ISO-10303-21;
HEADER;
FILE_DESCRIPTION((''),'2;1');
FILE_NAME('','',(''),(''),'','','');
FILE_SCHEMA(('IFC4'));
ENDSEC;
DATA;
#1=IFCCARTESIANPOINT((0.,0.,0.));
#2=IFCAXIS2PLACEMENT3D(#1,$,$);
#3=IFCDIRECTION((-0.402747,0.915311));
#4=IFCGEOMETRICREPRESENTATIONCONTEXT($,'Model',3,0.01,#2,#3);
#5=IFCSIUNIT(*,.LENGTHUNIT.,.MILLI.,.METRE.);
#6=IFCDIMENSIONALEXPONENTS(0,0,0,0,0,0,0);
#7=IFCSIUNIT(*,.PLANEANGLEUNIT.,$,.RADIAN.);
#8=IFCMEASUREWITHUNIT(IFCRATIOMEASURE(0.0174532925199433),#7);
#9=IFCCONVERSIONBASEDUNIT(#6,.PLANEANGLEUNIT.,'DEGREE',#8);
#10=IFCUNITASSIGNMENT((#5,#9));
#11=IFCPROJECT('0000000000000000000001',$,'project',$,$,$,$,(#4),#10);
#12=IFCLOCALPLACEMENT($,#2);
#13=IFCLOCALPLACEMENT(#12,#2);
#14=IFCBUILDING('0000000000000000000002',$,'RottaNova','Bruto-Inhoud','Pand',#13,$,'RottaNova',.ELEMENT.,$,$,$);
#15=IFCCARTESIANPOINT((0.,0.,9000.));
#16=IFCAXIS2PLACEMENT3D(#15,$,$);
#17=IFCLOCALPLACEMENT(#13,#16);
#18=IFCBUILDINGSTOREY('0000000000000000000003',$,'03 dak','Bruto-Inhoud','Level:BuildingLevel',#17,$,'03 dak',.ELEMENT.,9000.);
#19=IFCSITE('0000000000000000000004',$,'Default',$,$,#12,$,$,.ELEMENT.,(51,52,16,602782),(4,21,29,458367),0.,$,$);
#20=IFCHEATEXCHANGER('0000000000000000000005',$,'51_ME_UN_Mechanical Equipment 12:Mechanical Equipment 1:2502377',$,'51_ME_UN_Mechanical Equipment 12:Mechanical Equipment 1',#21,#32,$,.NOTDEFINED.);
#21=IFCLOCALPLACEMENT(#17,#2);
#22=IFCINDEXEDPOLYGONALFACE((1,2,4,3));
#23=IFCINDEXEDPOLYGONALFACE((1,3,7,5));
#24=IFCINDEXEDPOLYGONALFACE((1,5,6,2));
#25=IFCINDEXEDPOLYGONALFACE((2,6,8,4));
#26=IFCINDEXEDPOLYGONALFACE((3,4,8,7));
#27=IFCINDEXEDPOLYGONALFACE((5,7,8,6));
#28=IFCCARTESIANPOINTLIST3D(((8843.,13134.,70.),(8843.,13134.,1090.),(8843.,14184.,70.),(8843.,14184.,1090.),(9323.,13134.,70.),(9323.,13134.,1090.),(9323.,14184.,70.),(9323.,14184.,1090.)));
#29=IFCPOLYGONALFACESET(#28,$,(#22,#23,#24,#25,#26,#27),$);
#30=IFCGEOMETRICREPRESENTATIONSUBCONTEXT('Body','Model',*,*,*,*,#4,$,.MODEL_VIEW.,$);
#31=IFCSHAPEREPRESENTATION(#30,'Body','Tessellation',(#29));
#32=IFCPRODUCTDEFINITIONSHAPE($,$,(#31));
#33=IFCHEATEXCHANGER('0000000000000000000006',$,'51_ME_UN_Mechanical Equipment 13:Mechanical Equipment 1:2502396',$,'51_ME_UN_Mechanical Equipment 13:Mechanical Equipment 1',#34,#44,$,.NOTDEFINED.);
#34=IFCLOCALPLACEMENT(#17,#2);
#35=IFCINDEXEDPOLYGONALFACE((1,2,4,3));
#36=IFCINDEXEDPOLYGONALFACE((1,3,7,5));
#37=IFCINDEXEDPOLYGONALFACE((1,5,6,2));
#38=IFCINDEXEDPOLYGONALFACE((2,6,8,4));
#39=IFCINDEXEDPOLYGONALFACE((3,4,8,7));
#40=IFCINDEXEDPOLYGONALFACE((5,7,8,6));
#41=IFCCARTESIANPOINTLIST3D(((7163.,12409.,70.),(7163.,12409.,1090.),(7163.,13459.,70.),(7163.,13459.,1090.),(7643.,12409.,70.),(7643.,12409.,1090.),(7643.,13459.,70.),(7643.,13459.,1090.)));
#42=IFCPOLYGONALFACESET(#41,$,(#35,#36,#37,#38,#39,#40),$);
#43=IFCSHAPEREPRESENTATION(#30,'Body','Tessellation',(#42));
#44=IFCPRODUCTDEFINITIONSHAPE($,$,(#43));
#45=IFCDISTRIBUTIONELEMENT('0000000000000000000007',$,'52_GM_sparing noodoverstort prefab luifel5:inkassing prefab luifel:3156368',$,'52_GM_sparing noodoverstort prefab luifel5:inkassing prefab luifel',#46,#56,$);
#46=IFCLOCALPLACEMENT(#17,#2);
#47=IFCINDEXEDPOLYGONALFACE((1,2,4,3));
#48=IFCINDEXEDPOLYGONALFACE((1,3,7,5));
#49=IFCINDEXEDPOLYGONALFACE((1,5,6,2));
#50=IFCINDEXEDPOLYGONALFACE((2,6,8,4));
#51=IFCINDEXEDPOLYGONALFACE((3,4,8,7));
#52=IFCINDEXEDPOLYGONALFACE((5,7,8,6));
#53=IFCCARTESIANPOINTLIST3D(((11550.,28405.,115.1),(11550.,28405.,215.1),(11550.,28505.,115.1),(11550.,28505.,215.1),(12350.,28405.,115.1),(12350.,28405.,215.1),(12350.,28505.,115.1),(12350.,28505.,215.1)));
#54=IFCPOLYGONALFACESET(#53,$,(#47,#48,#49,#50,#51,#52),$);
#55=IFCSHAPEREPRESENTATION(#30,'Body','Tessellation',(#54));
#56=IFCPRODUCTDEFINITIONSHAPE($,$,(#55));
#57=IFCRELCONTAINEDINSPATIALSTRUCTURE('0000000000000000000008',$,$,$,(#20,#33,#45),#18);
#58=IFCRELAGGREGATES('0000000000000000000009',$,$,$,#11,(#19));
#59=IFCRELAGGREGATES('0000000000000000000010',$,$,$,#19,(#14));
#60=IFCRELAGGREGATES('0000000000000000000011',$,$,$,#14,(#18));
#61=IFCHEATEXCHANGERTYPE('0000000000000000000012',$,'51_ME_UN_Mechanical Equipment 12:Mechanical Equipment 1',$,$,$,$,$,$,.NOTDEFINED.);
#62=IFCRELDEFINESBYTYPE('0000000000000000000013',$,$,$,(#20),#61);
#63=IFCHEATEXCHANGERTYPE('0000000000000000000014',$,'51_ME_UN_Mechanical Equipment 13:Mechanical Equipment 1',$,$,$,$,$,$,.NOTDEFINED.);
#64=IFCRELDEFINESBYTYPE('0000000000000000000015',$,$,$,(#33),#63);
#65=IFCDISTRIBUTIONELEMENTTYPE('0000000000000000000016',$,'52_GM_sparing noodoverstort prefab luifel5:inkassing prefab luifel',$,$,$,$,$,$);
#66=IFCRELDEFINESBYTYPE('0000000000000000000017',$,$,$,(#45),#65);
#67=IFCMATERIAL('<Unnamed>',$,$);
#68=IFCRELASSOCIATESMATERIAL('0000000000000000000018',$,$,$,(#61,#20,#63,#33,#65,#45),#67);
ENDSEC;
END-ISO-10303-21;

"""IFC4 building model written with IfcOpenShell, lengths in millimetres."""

from ifc_helpers import new_model, entity, si_unit, converted_unit, direction, frame, frame_2d, origin, origin_2d_with_axis, place, context, subcontext, project, spatial, rectangle, extrude, source, transform, mapped, material, type_object, type_shapes, element, save


model = new_model("IFC4")

# Units and contexts
model_context = context("Model", 3, precision=0.01, world=origin(), true_north=direction((-0.402747, 0.915311)))
body_context = subcontext(model_context, "Body", "Model", "MODEL_VIEW")
ifc_project = project(units=[si_unit("LENGTHUNIT", "METRE", prefix="MILLI"), converted_unit("PLANEANGLEUNIT", "DEGREE", entity("IfcRatioMeasure", 0.0174532925199433), si_unit("PLANEANGLEUNIT", "RADIAN"), dimensions=[0, 0, 0, 0, 0, 0, 0])], contexts=[model_context])

# Site, building, storey
site_placement = place(None, origin())
site = spatial("IfcSite", under=ifc_project, at=site_placement, Name="Default", CompositionType="ELEMENT", RefLatitude=(51, 52, 16, 602782), RefLongitude=(4, 21, 29, 458367), RefElevation=0.0)
building_placement = place(site_placement, origin())
building = spatial("IfcBuilding", under=site, at=building_placement, Name="RottaNova", Description="Bruto-Inhoud", ObjectType="Pand", LongName="RottaNova", CompositionType="ELEMENT")
storey_placement = place(building_placement, frame((0.0, 0.0, 9000.0)))
storey = spatial("IfcBuildingStorey", under=building, at=storey_placement, Name="03 dak", Description="Bruto-Inhoud", ObjectType="Level:BuildingLevel", LongName="03 dak", CompositionType="ELEMENT", Elevation=9000.0)

# Heat exchangers
ifc_material_1 = material(Name="<Unnamed>")
heat_exchanger_type_1 = type_object("IfcHeatExchangerType", Name="51_ME_UN_Mechanical Equipment 12:Mechanical Equipment 1", PredefinedType="NOTDEFINED", material=ifc_material_1)
shared_shape_1 = source(origin(), body_context, "Body", "SweptSolid", [
    extrude(rectangle(XDim=1050.0, YDim=480.0, at=frame_2d((0.0, 0.0), x_axis=(1.0, 0.0))), frame((525.0, 240.0, 0.0), z_axis=(0.0, 0.0, 1.0), x_axis=(-1.0, 0.0, 0.0)), (0.0, 0.0, 1.0), 1020.0),
])
type_shapes(heat_exchanger_type_1, [shared_shape_1])
heat_exchanger_1_placement = place(storey_placement, frame((9323.0, 13134.0, 70.0), z_axis=(0.0, 0.0, 1.0), x_axis=(0.0, 1.0, 0.0)))
element("IfcHeatExchanger", 1, at=heat_exchanger_1_placement, inside=storey, type_object=heat_exchanger_type_1, material=ifc_material_1, Name="51_ME_UN_Mechanical Equipment 12:Mechanical Equipment 1:2502377", ObjectType="51_ME_UN_Mechanical Equipment 12:Mechanical Equipment 1", PredefinedType="NOTDEFINED", context=body_context, shape_type="MappedRepresentation", body=[
    mapped(shared_shape_1, transform((0.0, 0.0, 0.0), scale=1.0)),
])
heat_exchanger_type_2 = type_object("IfcHeatExchangerType", Name="51_ME_UN_Mechanical Equipment 13:Mechanical Equipment 1", PredefinedType="NOTDEFINED", material=ifc_material_1)
shared_shape_2 = source(origin(), body_context, "Body", "SweptSolid", [
    extrude(rectangle(XDim=1050.0, YDim=480.0, at=frame_2d((0.0, 0.0), x_axis=(1.0, 0.0))), frame((525.0, 240.0, 0.0), z_axis=(0.0, 0.0, 1.0), x_axis=(-1.0, 0.0, 0.0)), (0.0, 0.0, 1.0), 1020.0),
])
type_shapes(heat_exchanger_type_2, [shared_shape_2])
heat_exchanger_2_placement = place(storey_placement, frame((7643.0, 12409.0, 70.0), z_axis=(0.0, 0.0, 1.0), x_axis=(0.0, 1.0, 0.0)))
element("IfcHeatExchanger", 2, at=heat_exchanger_2_placement, inside=storey, type_object=heat_exchanger_type_2, material=ifc_material_1, Name="51_ME_UN_Mechanical Equipment 13:Mechanical Equipment 1:2502396", ObjectType="51_ME_UN_Mechanical Equipment 13:Mechanical Equipment 1", PredefinedType="NOTDEFINED", context=body_context, shape_type="MappedRepresentation", body=[
    mapped(shared_shape_2, transform((0.0, 0.0, 0.0), scale=1.0)),
])

# Distribution element
distribution_element_type = type_object("IfcDistributionElementType", Name="52_GM_sparing noodoverstort prefab luifel5:inkassing prefab luifel", material=ifc_material_1)
shared_shape_3 = source(origin(), body_context, "Body", "SweptSolid", [
    extrude(rectangle(XDim=100.0, YDim=800.0, at=origin_2d_with_axis()), frame((400.0, 50.0, 0.0), z_axis=(0.0, 0.0, 1.0), x_axis=(0.0, -1.0, 0.0)), (0.0, 0.0, 1.0), 100.0),
])
type_shapes(distribution_element_type, [shared_shape_3])
distribution_element_placement = place(storey_placement, frame((11550.0, 28405.0, 115.1)))
element("IfcDistributionElement", 3, at=distribution_element_placement, inside=storey, type_object=distribution_element_type, material=ifc_material_1, Name="52_GM_sparing noodoverstort prefab luifel5:inkassing prefab luifel:3156368", ObjectType="52_GM_sparing noodoverstort prefab luifel5:inkassing prefab luifel", context=body_context, shape_type="MappedRepresentation", body=[
    mapped(shared_shape_3, transform((0.0, 0.0, 0.0), scale=1.0)),
])

save(model, "model.ifc")
